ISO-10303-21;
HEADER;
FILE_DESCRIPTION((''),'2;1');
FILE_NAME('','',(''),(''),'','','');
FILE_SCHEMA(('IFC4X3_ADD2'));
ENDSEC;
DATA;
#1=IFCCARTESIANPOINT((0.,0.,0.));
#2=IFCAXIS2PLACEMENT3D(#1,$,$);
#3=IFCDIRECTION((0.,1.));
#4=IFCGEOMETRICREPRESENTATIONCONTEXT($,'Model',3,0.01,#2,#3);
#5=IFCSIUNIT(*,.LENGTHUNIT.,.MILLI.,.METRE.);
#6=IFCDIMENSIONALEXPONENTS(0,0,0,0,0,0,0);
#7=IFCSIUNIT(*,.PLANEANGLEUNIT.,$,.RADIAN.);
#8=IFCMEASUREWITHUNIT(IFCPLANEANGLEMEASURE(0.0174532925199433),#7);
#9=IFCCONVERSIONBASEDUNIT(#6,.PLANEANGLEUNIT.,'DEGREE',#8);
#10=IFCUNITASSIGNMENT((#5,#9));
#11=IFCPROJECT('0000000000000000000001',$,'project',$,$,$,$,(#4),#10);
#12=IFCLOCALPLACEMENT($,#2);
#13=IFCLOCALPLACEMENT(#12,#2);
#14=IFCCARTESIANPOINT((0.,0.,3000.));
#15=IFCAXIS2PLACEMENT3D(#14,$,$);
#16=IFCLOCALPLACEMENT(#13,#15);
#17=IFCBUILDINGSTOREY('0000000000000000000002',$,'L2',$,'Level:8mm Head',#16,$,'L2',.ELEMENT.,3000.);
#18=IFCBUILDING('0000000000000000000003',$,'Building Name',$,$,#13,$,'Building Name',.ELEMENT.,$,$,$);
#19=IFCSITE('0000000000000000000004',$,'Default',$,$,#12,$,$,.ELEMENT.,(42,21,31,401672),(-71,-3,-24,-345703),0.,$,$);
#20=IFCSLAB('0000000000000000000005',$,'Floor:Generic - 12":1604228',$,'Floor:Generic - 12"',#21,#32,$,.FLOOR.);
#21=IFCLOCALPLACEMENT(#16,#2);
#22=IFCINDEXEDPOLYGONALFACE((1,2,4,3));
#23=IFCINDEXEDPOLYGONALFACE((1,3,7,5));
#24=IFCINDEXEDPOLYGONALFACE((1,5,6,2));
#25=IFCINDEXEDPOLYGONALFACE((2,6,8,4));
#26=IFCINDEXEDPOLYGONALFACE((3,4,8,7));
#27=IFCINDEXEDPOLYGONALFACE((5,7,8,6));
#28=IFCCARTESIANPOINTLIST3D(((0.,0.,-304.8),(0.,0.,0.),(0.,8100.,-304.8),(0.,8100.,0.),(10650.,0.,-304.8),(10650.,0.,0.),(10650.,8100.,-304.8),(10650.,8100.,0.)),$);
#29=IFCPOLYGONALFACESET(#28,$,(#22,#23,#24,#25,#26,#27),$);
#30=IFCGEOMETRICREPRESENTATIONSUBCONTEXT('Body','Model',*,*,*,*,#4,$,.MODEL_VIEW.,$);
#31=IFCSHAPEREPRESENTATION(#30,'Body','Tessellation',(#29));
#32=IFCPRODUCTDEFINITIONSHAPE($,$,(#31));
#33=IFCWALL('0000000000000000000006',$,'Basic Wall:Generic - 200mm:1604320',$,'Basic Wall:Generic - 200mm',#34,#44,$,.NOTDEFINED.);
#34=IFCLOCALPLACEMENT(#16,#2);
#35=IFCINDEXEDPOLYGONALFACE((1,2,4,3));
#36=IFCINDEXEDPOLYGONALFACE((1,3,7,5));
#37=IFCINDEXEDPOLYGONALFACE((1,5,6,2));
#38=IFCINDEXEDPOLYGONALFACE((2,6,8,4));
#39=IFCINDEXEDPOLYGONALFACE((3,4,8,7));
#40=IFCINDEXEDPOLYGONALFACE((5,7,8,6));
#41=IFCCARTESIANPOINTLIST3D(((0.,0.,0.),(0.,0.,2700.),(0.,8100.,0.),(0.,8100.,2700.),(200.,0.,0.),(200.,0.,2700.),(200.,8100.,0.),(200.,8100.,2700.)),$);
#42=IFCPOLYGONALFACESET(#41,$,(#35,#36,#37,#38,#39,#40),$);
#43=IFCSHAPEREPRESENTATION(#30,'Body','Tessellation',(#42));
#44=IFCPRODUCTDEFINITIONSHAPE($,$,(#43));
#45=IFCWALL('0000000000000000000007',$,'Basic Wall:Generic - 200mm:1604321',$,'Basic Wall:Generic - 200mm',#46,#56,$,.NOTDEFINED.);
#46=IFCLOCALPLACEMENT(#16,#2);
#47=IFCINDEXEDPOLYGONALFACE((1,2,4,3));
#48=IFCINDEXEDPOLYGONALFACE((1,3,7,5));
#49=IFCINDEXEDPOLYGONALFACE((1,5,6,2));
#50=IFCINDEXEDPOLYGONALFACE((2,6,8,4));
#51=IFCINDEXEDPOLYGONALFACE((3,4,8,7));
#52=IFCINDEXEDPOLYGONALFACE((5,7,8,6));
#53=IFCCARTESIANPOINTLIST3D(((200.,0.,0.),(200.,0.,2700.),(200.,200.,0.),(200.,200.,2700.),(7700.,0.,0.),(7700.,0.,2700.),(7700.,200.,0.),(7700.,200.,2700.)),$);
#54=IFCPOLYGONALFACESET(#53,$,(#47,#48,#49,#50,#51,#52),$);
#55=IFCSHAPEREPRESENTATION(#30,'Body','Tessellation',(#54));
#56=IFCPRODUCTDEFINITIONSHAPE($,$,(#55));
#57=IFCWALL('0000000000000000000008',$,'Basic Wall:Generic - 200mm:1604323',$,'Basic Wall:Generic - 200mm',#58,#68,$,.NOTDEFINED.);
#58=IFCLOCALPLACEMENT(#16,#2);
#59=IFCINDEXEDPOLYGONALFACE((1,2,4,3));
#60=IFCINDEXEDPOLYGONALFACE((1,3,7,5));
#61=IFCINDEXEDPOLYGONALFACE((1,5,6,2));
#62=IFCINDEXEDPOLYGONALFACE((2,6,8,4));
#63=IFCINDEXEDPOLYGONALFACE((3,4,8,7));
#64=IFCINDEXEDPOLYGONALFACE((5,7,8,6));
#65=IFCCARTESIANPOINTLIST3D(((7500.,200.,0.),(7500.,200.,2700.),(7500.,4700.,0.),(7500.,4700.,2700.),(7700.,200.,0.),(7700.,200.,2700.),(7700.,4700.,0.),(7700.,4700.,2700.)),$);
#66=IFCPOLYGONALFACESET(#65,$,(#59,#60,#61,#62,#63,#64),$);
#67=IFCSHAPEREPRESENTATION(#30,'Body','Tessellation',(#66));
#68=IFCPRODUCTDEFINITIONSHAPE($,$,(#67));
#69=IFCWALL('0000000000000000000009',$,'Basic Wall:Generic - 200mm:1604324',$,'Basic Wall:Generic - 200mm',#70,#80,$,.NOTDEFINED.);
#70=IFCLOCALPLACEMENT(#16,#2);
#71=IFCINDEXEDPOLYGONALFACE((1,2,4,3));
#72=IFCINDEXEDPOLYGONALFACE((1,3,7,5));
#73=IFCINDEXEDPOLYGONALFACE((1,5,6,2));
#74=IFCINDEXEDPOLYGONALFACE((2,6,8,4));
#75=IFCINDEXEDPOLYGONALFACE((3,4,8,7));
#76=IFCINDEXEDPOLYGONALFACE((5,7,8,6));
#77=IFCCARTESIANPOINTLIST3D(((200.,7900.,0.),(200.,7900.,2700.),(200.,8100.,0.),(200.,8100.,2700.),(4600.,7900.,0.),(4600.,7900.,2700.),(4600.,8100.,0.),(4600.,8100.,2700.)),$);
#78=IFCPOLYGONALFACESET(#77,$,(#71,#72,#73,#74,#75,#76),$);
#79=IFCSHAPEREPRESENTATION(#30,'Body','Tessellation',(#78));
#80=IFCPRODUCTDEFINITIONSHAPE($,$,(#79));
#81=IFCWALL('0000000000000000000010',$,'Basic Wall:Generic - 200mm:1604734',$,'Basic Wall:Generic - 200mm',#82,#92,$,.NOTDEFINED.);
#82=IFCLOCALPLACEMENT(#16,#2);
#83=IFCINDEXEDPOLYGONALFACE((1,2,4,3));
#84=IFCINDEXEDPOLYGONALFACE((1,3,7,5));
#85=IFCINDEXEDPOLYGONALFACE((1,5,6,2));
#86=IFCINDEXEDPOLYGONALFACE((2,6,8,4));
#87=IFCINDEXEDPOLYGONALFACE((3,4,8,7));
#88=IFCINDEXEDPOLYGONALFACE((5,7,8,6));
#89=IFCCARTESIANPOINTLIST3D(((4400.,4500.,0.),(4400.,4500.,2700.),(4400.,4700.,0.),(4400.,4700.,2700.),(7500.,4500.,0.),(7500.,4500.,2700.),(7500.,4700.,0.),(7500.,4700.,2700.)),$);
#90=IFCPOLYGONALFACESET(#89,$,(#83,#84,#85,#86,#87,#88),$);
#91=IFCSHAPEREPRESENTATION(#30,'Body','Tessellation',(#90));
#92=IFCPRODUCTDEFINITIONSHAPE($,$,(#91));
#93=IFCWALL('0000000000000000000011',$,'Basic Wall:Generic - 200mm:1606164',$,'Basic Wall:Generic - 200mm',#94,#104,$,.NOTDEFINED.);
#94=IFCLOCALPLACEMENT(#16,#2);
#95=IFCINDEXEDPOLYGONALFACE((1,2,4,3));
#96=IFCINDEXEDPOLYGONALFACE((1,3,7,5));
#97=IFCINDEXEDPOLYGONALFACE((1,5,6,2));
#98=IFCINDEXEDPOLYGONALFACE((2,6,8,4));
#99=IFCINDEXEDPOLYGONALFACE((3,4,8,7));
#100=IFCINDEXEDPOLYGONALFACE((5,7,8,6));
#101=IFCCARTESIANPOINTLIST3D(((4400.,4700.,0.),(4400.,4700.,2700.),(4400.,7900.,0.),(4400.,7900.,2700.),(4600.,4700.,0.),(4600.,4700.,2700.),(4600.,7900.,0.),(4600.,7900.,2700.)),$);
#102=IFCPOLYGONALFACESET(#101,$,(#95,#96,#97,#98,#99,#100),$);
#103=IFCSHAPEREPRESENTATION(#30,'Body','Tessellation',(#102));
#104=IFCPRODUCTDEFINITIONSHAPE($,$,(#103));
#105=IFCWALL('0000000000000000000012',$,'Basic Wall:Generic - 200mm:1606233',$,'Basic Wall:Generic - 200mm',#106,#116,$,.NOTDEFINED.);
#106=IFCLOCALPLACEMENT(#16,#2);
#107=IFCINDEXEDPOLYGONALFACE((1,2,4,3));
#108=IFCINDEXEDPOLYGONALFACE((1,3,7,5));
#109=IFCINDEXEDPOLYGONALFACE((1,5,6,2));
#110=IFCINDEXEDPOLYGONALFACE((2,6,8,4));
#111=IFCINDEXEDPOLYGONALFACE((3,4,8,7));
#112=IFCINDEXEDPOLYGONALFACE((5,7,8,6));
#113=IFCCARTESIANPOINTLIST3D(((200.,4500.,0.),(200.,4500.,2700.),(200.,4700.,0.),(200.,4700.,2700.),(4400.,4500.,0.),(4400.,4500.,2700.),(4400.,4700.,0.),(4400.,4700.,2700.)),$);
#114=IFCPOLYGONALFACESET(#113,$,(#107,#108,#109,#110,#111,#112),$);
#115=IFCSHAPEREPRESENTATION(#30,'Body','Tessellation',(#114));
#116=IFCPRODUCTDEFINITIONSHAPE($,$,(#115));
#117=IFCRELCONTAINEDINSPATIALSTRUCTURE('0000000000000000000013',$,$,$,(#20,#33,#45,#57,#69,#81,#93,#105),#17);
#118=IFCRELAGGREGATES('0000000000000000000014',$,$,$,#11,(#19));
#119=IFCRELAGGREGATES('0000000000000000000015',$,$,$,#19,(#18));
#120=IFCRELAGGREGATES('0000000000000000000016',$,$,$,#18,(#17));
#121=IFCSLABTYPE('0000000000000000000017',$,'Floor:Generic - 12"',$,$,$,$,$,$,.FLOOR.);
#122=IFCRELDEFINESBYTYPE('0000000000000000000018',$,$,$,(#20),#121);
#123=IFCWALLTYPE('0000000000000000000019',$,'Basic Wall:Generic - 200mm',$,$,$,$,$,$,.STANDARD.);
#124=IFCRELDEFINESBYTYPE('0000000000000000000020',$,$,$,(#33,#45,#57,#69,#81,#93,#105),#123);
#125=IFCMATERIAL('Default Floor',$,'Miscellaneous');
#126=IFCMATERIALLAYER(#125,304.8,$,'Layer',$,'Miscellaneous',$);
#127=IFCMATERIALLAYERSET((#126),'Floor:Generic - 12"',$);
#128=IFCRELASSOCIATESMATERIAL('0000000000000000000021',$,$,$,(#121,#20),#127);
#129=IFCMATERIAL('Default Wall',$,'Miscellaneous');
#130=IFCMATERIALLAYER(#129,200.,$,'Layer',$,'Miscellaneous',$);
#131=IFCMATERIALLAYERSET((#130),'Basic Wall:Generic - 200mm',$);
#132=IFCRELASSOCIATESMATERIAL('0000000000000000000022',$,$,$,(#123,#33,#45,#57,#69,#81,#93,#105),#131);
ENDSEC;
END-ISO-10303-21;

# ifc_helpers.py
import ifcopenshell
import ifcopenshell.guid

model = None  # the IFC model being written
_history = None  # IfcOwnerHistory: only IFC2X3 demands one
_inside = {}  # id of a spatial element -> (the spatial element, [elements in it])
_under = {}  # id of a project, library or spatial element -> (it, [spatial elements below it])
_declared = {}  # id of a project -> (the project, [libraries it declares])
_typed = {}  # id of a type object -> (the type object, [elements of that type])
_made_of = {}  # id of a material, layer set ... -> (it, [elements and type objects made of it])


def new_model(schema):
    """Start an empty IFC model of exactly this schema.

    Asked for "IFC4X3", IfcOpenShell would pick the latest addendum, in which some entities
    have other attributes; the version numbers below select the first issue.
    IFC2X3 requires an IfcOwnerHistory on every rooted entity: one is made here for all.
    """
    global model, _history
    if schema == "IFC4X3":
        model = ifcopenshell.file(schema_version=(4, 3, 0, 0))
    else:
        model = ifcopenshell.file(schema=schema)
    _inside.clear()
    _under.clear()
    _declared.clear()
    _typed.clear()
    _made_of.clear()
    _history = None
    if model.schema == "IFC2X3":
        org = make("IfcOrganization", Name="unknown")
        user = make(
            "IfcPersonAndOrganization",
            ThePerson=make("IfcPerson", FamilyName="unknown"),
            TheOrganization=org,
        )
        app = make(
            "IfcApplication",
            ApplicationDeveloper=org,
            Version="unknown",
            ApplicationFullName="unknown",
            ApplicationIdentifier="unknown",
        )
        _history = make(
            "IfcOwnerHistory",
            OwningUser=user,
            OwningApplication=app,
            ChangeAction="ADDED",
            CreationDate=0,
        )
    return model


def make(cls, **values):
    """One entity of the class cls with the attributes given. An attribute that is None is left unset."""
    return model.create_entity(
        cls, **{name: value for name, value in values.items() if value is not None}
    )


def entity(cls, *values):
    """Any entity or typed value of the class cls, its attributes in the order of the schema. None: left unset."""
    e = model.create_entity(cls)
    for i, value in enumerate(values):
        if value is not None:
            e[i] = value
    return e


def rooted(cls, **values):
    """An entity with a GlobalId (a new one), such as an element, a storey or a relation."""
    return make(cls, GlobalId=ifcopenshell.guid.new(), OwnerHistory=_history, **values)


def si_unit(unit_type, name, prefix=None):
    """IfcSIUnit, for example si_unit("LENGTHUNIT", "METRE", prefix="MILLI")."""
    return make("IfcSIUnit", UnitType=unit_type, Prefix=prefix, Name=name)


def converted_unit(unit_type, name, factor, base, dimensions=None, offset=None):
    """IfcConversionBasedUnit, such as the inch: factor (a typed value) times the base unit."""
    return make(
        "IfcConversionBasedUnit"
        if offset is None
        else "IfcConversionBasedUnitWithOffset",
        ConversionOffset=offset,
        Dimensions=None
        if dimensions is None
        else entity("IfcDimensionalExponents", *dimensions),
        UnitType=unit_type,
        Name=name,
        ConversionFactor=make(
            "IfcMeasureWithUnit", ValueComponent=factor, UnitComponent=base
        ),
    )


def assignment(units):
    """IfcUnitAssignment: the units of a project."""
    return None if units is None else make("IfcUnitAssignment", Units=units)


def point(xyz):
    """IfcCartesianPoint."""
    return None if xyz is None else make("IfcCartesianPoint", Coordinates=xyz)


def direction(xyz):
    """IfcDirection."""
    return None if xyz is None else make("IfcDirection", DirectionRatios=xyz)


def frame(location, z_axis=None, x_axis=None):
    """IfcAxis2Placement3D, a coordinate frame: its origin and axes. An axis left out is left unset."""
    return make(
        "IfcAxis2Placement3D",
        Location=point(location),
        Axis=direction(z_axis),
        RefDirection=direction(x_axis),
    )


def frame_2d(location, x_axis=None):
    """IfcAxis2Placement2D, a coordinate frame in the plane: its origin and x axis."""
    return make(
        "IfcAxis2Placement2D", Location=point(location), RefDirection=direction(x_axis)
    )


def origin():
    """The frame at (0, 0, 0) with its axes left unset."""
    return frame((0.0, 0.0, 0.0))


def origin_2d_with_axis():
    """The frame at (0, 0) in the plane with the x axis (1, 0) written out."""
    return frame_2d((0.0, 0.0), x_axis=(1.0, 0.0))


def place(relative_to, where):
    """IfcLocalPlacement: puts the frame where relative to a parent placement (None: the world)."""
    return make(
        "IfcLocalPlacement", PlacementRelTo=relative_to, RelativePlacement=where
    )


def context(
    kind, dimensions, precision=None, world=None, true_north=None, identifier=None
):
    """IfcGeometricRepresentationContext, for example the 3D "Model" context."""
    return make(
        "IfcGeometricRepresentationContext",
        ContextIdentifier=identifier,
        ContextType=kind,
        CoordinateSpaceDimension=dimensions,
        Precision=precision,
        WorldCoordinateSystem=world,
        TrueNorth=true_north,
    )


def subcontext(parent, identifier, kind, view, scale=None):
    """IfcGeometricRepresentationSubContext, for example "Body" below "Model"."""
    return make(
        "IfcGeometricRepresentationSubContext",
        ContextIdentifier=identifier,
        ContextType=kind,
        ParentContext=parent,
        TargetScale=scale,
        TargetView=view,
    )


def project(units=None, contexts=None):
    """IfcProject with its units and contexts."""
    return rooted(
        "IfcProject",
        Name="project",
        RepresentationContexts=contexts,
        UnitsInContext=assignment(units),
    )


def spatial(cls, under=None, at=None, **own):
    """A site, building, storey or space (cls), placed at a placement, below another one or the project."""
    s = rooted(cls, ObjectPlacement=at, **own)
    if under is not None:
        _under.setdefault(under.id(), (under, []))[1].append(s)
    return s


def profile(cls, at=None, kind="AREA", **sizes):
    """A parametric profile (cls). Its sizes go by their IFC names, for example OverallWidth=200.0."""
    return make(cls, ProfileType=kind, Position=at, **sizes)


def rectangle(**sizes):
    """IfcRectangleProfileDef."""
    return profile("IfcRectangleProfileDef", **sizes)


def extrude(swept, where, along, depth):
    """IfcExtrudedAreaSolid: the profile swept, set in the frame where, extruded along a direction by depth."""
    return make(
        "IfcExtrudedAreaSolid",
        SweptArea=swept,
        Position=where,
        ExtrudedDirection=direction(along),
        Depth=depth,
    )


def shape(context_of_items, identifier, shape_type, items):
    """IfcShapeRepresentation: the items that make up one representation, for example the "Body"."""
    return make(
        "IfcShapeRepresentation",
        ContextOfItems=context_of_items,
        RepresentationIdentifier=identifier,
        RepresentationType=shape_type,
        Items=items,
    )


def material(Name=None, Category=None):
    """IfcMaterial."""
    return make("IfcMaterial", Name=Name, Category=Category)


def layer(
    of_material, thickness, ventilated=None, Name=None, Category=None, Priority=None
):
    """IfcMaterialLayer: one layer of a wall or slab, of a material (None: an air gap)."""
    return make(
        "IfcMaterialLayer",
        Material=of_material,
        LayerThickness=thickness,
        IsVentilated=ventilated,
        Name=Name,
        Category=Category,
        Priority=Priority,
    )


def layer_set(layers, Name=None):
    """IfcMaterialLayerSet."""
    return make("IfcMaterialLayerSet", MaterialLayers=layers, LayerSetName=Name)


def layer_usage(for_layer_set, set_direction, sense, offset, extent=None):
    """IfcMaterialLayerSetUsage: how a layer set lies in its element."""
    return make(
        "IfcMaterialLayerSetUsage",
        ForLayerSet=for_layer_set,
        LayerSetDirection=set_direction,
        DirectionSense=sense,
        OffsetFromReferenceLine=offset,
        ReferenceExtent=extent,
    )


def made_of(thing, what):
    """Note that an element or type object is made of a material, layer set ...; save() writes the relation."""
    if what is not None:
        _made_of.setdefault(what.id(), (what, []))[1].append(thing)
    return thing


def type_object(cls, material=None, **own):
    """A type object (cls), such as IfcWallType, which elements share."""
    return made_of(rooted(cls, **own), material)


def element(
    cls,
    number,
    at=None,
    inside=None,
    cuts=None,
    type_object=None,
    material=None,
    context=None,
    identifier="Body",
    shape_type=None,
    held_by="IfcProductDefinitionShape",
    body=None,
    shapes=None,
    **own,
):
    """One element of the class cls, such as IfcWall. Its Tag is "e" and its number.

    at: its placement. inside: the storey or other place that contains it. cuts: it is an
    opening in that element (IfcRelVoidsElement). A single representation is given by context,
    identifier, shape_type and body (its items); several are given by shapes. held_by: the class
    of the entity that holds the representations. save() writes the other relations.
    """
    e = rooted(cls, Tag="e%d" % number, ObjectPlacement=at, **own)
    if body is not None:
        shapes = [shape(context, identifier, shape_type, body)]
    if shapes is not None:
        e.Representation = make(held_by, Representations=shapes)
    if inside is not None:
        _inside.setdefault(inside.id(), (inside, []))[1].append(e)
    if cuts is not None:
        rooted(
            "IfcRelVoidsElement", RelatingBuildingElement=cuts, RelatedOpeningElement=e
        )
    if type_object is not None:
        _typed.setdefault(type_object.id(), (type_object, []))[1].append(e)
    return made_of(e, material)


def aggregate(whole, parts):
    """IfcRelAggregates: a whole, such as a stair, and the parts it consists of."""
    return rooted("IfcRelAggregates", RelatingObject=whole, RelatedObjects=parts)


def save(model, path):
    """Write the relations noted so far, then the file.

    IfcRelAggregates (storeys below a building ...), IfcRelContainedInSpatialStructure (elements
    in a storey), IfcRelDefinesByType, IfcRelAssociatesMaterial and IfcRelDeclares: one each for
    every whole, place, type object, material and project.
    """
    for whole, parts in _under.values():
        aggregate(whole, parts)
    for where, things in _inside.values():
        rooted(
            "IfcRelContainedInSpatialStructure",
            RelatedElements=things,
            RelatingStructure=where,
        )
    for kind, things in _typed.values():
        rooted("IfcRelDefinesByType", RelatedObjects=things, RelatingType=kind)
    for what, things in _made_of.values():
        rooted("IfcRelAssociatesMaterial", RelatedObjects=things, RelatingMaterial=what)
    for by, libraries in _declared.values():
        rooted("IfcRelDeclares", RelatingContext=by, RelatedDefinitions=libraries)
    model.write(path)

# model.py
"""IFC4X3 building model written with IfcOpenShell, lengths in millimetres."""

from ifc_helpers import new_model, entity, si_unit, converted_unit, direction, frame, frame_2d, origin, origin_2d_with_axis, place, context, subcontext, project, spatial, rectangle, extrude, material, layer, layer_set, layer_usage, type_object, element, save


model = new_model("IFC4X3")

# Units and contexts
model_context = context("Model", 3, precision=0.01, world=origin(), true_north=direction((0.0, 1.0)))
body_context = subcontext(model_context, "Body", "Model", "MODEL_VIEW")
ifc_project = project(units=[si_unit("LENGTHUNIT", "METRE", prefix="MILLI"), converted_unit("PLANEANGLEUNIT", "DEGREE", entity("IfcPlaneAngleMeasure", 0.0174532925199433), si_unit("PLANEANGLEUNIT", "RADIAN"), dimensions=[0, 0, 0, 0, 0, 0, 0])], contexts=[model_context])

# Site, building, storey
site_placement = place(None, origin())
site = spatial("IfcSite", under=ifc_project, at=site_placement, Name="Default", CompositionType="ELEMENT", RefLatitude=(42, 21, 31, 401672), RefLongitude=(-71, -3, -24, -345703), RefElevation=0.0)
building_placement = place(site_placement, origin())
building = spatial("IfcBuilding", under=site, at=building_placement, Name="Building Name", LongName="Building Name", CompositionType="ELEMENT")
storey_placement = place(building_placement, frame((0.0, 0.0, 3000.0)))
storey = spatial("IfcBuildingStorey", under=building, at=storey_placement, Name="L2", ObjectType="Level:8mm Head", LongName="L2", CompositionType="ELEMENT", Elevation=3000.0)

# Slab
ifc_material_1 = material(Name="Default Floor", Category="Miscellaneous")
ifc_layer_1 = layer(ifc_material_1, 304.8, Name="Layer", Category="Miscellaneous")
ifc_layer_set_1 = layer_set([ifc_layer_1], Name="Floor:Generic - 12\"")
ifc_layer_usage = layer_usage(ifc_layer_set_1, "AXIS3", "POSITIVE", 0.0)
slab_type = type_object("IfcSlabType", Name="Floor:Generic - 12\"", PredefinedType="FLOOR", material=ifc_layer_set_1)
slab_placement = place(storey_placement, origin())
element("IfcSlab", 1, at=slab_placement, inside=storey, type_object=slab_type, material=ifc_layer_usage, Name="Floor:Generic - 12\":1604228", ObjectType="Floor:Generic - 12\"", PredefinedType="FLOOR", context=body_context, shape_type="SweptSolid", body=[
    extrude(rectangle(XDim=8100.0, YDim=10650.0, at=origin_2d_with_axis()), frame((5325.0, 4050.0, 0.0), z_axis=(0.0, 0.0, -1.0), x_axis=(0.0, 1.0, 0.0)), (0.0, 0.0, 1.0), 304.8),
])

# Walls
ifc_material_2 = material(Name="Default Wall", Category="Miscellaneous")
ifc_layer_2 = layer(ifc_material_2, 200.0, Name="Layer", Category="Miscellaneous")
ifc_layer_set_2 = layer_set([ifc_layer_2], Name="Basic Wall:Generic - 200mm")
wall_type = type_object("IfcWallType", Name="Basic Wall:Generic - 200mm", PredefinedType="STANDARD", material=ifc_layer_set_2)
wall_1_placement = place(storey_placement, frame((100.0, 8100.0, 0.0), z_axis=(0.0, 0.0, 1.0), x_axis=(0.0, -1.0, 0.0)))
element("IfcWall", 2, at=wall_1_placement, inside=storey, type_object=wall_type, material=ifc_layer_set_2, Name="Basic Wall:Generic - 200mm:1604320", ObjectType="Basic Wall:Generic - 200mm", PredefinedType="NOTDEFINED", context=body_context, shape_type="SweptSolid", body=[
    extrude(rectangle(XDim=8100.0, YDim=200.0, at=frame_2d((4050.0, 0.0), x_axis=(-1.0, 0.0))), origin(), (0.0, 0.0, 1.0), 2700.0),
])
wall_2_placement = place(storey_placement, frame((200.0, 100.0, 0.0)))
element("IfcWall", 3, at=wall_2_placement, inside=storey, type_object=wall_type, material=ifc_layer_set_2, Name="Basic Wall:Generic - 200mm:1604321", ObjectType="Basic Wall:Generic - 200mm", PredefinedType="NOTDEFINED", context=body_context, shape_type="SweptSolid", body=[
    extrude(rectangle(XDim=7500.0, YDim=200.0, at=frame_2d((3750.0, 0.0), x_axis=(-1.0, 0.0))), origin(), (0.0, 0.0, 1.0), 2700.0),
])
wall_3_placement = place(storey_placement, frame((7600.0, 200.0, 0.0), z_axis=(0.0, 0.0, 1.0), x_axis=(0.0, 1.0, 0.0)))
element("IfcWall", 4, at=wall_3_placement, inside=storey, type_object=wall_type, material=ifc_layer_set_2, Name="Basic Wall:Generic - 200mm:1604323", ObjectType="Basic Wall:Generic - 200mm", PredefinedType="NOTDEFINED", context=body_context, shape_type="SweptSolid", body=[
    extrude(rectangle(XDim=4500.0, YDim=200.0, at=frame_2d((2250.0, 0.0), x_axis=(-1.0, 0.0))), origin(), (0.0, 0.0, 1.0), 2700.0),
])
wall_4_placement = place(storey_placement, frame((4600.0, 8000.0, 0.0), z_axis=(0.0, 0.0, 1.0), x_axis=(-1.0, 0.0, 0.0)))
element("IfcWall", 5, at=wall_4_placement, inside=storey, type_object=wall_type, material=ifc_layer_set_2, Name="Basic Wall:Generic - 200mm:1604324", ObjectType="Basic Wall:Generic - 200mm", PredefinedType="NOTDEFINED", context=body_context, shape_type="SweptSolid", body=[
    extrude(rectangle(XDim=4400.0, YDim=200.0, at=frame_2d((2200.0, 0.0), x_axis=(-1.0, 0.0))), origin(), (0.0, 0.0, 1.0), 2700.0),
])
wall_5_placement = place(storey_placement, frame((7500.0, 4600.0, 0.0), z_axis=(0.0, 0.0, 1.0), x_axis=(-1.0, 0.0, 0.0)))
element("IfcWall", 6, at=wall_5_placement, inside=storey, type_object=wall_type, material=ifc_layer_set_2, Name="Basic Wall:Generic - 200mm:1604734", ObjectType="Basic Wall:Generic - 200mm", PredefinedType="NOTDEFINED", context=body_context, shape_type="SweptSolid", body=[
    extrude(rectangle(XDim=3100.0, YDim=200.0, at=frame_2d((1550.0, 0.0), x_axis=(-1.0, 0.0))), origin(), (0.0, 0.0, 1.0), 2700.0),
])
wall_6_placement = place(storey_placement, frame((4500.0, 7900.0, 0.0), z_axis=(0.0, 0.0, 1.0), x_axis=(0.0, -1.0, 0.0)))
element("IfcWall", 7, at=wall_6_placement, inside=storey, type_object=wall_type, material=ifc_layer_set_2, Name="Basic Wall:Generic - 200mm:1606164", ObjectType="Basic Wall:Generic - 200mm", PredefinedType="NOTDEFINED", context=body_context, shape_type="SweptSolid", body=[
    extrude(rectangle(XDim=3200.0, YDim=200.0, at=frame_2d((1600.0, 0.0), x_axis=(-1.0, 0.0))), origin(), (0.0, 0.0, 1.0), 2700.0),
])
wall_7_placement = place(storey_placement, frame((4400.0, 4600.0, 0.0), z_axis=(0.0, 0.0, 1.0), x_axis=(-1.0, 0.0, 0.0)))
element("IfcWall", 8, at=wall_7_placement, inside=storey, type_object=wall_type, material=ifc_layer_set_2, Name="Basic Wall:Generic - 200mm:1606233", ObjectType="Basic Wall:Generic - 200mm", PredefinedType="NOTDEFINED", context=body_context, shape_type="SweptSolid", body=[
    extrude(rectangle(XDim=4200.0, YDim=200.0, at=frame_2d((2100.0, 0.0), x_axis=(-1.0, 0.0))), origin(), (0.0, 0.0, 1.0), 2700.0),
])

save(model, "model.ifc")
